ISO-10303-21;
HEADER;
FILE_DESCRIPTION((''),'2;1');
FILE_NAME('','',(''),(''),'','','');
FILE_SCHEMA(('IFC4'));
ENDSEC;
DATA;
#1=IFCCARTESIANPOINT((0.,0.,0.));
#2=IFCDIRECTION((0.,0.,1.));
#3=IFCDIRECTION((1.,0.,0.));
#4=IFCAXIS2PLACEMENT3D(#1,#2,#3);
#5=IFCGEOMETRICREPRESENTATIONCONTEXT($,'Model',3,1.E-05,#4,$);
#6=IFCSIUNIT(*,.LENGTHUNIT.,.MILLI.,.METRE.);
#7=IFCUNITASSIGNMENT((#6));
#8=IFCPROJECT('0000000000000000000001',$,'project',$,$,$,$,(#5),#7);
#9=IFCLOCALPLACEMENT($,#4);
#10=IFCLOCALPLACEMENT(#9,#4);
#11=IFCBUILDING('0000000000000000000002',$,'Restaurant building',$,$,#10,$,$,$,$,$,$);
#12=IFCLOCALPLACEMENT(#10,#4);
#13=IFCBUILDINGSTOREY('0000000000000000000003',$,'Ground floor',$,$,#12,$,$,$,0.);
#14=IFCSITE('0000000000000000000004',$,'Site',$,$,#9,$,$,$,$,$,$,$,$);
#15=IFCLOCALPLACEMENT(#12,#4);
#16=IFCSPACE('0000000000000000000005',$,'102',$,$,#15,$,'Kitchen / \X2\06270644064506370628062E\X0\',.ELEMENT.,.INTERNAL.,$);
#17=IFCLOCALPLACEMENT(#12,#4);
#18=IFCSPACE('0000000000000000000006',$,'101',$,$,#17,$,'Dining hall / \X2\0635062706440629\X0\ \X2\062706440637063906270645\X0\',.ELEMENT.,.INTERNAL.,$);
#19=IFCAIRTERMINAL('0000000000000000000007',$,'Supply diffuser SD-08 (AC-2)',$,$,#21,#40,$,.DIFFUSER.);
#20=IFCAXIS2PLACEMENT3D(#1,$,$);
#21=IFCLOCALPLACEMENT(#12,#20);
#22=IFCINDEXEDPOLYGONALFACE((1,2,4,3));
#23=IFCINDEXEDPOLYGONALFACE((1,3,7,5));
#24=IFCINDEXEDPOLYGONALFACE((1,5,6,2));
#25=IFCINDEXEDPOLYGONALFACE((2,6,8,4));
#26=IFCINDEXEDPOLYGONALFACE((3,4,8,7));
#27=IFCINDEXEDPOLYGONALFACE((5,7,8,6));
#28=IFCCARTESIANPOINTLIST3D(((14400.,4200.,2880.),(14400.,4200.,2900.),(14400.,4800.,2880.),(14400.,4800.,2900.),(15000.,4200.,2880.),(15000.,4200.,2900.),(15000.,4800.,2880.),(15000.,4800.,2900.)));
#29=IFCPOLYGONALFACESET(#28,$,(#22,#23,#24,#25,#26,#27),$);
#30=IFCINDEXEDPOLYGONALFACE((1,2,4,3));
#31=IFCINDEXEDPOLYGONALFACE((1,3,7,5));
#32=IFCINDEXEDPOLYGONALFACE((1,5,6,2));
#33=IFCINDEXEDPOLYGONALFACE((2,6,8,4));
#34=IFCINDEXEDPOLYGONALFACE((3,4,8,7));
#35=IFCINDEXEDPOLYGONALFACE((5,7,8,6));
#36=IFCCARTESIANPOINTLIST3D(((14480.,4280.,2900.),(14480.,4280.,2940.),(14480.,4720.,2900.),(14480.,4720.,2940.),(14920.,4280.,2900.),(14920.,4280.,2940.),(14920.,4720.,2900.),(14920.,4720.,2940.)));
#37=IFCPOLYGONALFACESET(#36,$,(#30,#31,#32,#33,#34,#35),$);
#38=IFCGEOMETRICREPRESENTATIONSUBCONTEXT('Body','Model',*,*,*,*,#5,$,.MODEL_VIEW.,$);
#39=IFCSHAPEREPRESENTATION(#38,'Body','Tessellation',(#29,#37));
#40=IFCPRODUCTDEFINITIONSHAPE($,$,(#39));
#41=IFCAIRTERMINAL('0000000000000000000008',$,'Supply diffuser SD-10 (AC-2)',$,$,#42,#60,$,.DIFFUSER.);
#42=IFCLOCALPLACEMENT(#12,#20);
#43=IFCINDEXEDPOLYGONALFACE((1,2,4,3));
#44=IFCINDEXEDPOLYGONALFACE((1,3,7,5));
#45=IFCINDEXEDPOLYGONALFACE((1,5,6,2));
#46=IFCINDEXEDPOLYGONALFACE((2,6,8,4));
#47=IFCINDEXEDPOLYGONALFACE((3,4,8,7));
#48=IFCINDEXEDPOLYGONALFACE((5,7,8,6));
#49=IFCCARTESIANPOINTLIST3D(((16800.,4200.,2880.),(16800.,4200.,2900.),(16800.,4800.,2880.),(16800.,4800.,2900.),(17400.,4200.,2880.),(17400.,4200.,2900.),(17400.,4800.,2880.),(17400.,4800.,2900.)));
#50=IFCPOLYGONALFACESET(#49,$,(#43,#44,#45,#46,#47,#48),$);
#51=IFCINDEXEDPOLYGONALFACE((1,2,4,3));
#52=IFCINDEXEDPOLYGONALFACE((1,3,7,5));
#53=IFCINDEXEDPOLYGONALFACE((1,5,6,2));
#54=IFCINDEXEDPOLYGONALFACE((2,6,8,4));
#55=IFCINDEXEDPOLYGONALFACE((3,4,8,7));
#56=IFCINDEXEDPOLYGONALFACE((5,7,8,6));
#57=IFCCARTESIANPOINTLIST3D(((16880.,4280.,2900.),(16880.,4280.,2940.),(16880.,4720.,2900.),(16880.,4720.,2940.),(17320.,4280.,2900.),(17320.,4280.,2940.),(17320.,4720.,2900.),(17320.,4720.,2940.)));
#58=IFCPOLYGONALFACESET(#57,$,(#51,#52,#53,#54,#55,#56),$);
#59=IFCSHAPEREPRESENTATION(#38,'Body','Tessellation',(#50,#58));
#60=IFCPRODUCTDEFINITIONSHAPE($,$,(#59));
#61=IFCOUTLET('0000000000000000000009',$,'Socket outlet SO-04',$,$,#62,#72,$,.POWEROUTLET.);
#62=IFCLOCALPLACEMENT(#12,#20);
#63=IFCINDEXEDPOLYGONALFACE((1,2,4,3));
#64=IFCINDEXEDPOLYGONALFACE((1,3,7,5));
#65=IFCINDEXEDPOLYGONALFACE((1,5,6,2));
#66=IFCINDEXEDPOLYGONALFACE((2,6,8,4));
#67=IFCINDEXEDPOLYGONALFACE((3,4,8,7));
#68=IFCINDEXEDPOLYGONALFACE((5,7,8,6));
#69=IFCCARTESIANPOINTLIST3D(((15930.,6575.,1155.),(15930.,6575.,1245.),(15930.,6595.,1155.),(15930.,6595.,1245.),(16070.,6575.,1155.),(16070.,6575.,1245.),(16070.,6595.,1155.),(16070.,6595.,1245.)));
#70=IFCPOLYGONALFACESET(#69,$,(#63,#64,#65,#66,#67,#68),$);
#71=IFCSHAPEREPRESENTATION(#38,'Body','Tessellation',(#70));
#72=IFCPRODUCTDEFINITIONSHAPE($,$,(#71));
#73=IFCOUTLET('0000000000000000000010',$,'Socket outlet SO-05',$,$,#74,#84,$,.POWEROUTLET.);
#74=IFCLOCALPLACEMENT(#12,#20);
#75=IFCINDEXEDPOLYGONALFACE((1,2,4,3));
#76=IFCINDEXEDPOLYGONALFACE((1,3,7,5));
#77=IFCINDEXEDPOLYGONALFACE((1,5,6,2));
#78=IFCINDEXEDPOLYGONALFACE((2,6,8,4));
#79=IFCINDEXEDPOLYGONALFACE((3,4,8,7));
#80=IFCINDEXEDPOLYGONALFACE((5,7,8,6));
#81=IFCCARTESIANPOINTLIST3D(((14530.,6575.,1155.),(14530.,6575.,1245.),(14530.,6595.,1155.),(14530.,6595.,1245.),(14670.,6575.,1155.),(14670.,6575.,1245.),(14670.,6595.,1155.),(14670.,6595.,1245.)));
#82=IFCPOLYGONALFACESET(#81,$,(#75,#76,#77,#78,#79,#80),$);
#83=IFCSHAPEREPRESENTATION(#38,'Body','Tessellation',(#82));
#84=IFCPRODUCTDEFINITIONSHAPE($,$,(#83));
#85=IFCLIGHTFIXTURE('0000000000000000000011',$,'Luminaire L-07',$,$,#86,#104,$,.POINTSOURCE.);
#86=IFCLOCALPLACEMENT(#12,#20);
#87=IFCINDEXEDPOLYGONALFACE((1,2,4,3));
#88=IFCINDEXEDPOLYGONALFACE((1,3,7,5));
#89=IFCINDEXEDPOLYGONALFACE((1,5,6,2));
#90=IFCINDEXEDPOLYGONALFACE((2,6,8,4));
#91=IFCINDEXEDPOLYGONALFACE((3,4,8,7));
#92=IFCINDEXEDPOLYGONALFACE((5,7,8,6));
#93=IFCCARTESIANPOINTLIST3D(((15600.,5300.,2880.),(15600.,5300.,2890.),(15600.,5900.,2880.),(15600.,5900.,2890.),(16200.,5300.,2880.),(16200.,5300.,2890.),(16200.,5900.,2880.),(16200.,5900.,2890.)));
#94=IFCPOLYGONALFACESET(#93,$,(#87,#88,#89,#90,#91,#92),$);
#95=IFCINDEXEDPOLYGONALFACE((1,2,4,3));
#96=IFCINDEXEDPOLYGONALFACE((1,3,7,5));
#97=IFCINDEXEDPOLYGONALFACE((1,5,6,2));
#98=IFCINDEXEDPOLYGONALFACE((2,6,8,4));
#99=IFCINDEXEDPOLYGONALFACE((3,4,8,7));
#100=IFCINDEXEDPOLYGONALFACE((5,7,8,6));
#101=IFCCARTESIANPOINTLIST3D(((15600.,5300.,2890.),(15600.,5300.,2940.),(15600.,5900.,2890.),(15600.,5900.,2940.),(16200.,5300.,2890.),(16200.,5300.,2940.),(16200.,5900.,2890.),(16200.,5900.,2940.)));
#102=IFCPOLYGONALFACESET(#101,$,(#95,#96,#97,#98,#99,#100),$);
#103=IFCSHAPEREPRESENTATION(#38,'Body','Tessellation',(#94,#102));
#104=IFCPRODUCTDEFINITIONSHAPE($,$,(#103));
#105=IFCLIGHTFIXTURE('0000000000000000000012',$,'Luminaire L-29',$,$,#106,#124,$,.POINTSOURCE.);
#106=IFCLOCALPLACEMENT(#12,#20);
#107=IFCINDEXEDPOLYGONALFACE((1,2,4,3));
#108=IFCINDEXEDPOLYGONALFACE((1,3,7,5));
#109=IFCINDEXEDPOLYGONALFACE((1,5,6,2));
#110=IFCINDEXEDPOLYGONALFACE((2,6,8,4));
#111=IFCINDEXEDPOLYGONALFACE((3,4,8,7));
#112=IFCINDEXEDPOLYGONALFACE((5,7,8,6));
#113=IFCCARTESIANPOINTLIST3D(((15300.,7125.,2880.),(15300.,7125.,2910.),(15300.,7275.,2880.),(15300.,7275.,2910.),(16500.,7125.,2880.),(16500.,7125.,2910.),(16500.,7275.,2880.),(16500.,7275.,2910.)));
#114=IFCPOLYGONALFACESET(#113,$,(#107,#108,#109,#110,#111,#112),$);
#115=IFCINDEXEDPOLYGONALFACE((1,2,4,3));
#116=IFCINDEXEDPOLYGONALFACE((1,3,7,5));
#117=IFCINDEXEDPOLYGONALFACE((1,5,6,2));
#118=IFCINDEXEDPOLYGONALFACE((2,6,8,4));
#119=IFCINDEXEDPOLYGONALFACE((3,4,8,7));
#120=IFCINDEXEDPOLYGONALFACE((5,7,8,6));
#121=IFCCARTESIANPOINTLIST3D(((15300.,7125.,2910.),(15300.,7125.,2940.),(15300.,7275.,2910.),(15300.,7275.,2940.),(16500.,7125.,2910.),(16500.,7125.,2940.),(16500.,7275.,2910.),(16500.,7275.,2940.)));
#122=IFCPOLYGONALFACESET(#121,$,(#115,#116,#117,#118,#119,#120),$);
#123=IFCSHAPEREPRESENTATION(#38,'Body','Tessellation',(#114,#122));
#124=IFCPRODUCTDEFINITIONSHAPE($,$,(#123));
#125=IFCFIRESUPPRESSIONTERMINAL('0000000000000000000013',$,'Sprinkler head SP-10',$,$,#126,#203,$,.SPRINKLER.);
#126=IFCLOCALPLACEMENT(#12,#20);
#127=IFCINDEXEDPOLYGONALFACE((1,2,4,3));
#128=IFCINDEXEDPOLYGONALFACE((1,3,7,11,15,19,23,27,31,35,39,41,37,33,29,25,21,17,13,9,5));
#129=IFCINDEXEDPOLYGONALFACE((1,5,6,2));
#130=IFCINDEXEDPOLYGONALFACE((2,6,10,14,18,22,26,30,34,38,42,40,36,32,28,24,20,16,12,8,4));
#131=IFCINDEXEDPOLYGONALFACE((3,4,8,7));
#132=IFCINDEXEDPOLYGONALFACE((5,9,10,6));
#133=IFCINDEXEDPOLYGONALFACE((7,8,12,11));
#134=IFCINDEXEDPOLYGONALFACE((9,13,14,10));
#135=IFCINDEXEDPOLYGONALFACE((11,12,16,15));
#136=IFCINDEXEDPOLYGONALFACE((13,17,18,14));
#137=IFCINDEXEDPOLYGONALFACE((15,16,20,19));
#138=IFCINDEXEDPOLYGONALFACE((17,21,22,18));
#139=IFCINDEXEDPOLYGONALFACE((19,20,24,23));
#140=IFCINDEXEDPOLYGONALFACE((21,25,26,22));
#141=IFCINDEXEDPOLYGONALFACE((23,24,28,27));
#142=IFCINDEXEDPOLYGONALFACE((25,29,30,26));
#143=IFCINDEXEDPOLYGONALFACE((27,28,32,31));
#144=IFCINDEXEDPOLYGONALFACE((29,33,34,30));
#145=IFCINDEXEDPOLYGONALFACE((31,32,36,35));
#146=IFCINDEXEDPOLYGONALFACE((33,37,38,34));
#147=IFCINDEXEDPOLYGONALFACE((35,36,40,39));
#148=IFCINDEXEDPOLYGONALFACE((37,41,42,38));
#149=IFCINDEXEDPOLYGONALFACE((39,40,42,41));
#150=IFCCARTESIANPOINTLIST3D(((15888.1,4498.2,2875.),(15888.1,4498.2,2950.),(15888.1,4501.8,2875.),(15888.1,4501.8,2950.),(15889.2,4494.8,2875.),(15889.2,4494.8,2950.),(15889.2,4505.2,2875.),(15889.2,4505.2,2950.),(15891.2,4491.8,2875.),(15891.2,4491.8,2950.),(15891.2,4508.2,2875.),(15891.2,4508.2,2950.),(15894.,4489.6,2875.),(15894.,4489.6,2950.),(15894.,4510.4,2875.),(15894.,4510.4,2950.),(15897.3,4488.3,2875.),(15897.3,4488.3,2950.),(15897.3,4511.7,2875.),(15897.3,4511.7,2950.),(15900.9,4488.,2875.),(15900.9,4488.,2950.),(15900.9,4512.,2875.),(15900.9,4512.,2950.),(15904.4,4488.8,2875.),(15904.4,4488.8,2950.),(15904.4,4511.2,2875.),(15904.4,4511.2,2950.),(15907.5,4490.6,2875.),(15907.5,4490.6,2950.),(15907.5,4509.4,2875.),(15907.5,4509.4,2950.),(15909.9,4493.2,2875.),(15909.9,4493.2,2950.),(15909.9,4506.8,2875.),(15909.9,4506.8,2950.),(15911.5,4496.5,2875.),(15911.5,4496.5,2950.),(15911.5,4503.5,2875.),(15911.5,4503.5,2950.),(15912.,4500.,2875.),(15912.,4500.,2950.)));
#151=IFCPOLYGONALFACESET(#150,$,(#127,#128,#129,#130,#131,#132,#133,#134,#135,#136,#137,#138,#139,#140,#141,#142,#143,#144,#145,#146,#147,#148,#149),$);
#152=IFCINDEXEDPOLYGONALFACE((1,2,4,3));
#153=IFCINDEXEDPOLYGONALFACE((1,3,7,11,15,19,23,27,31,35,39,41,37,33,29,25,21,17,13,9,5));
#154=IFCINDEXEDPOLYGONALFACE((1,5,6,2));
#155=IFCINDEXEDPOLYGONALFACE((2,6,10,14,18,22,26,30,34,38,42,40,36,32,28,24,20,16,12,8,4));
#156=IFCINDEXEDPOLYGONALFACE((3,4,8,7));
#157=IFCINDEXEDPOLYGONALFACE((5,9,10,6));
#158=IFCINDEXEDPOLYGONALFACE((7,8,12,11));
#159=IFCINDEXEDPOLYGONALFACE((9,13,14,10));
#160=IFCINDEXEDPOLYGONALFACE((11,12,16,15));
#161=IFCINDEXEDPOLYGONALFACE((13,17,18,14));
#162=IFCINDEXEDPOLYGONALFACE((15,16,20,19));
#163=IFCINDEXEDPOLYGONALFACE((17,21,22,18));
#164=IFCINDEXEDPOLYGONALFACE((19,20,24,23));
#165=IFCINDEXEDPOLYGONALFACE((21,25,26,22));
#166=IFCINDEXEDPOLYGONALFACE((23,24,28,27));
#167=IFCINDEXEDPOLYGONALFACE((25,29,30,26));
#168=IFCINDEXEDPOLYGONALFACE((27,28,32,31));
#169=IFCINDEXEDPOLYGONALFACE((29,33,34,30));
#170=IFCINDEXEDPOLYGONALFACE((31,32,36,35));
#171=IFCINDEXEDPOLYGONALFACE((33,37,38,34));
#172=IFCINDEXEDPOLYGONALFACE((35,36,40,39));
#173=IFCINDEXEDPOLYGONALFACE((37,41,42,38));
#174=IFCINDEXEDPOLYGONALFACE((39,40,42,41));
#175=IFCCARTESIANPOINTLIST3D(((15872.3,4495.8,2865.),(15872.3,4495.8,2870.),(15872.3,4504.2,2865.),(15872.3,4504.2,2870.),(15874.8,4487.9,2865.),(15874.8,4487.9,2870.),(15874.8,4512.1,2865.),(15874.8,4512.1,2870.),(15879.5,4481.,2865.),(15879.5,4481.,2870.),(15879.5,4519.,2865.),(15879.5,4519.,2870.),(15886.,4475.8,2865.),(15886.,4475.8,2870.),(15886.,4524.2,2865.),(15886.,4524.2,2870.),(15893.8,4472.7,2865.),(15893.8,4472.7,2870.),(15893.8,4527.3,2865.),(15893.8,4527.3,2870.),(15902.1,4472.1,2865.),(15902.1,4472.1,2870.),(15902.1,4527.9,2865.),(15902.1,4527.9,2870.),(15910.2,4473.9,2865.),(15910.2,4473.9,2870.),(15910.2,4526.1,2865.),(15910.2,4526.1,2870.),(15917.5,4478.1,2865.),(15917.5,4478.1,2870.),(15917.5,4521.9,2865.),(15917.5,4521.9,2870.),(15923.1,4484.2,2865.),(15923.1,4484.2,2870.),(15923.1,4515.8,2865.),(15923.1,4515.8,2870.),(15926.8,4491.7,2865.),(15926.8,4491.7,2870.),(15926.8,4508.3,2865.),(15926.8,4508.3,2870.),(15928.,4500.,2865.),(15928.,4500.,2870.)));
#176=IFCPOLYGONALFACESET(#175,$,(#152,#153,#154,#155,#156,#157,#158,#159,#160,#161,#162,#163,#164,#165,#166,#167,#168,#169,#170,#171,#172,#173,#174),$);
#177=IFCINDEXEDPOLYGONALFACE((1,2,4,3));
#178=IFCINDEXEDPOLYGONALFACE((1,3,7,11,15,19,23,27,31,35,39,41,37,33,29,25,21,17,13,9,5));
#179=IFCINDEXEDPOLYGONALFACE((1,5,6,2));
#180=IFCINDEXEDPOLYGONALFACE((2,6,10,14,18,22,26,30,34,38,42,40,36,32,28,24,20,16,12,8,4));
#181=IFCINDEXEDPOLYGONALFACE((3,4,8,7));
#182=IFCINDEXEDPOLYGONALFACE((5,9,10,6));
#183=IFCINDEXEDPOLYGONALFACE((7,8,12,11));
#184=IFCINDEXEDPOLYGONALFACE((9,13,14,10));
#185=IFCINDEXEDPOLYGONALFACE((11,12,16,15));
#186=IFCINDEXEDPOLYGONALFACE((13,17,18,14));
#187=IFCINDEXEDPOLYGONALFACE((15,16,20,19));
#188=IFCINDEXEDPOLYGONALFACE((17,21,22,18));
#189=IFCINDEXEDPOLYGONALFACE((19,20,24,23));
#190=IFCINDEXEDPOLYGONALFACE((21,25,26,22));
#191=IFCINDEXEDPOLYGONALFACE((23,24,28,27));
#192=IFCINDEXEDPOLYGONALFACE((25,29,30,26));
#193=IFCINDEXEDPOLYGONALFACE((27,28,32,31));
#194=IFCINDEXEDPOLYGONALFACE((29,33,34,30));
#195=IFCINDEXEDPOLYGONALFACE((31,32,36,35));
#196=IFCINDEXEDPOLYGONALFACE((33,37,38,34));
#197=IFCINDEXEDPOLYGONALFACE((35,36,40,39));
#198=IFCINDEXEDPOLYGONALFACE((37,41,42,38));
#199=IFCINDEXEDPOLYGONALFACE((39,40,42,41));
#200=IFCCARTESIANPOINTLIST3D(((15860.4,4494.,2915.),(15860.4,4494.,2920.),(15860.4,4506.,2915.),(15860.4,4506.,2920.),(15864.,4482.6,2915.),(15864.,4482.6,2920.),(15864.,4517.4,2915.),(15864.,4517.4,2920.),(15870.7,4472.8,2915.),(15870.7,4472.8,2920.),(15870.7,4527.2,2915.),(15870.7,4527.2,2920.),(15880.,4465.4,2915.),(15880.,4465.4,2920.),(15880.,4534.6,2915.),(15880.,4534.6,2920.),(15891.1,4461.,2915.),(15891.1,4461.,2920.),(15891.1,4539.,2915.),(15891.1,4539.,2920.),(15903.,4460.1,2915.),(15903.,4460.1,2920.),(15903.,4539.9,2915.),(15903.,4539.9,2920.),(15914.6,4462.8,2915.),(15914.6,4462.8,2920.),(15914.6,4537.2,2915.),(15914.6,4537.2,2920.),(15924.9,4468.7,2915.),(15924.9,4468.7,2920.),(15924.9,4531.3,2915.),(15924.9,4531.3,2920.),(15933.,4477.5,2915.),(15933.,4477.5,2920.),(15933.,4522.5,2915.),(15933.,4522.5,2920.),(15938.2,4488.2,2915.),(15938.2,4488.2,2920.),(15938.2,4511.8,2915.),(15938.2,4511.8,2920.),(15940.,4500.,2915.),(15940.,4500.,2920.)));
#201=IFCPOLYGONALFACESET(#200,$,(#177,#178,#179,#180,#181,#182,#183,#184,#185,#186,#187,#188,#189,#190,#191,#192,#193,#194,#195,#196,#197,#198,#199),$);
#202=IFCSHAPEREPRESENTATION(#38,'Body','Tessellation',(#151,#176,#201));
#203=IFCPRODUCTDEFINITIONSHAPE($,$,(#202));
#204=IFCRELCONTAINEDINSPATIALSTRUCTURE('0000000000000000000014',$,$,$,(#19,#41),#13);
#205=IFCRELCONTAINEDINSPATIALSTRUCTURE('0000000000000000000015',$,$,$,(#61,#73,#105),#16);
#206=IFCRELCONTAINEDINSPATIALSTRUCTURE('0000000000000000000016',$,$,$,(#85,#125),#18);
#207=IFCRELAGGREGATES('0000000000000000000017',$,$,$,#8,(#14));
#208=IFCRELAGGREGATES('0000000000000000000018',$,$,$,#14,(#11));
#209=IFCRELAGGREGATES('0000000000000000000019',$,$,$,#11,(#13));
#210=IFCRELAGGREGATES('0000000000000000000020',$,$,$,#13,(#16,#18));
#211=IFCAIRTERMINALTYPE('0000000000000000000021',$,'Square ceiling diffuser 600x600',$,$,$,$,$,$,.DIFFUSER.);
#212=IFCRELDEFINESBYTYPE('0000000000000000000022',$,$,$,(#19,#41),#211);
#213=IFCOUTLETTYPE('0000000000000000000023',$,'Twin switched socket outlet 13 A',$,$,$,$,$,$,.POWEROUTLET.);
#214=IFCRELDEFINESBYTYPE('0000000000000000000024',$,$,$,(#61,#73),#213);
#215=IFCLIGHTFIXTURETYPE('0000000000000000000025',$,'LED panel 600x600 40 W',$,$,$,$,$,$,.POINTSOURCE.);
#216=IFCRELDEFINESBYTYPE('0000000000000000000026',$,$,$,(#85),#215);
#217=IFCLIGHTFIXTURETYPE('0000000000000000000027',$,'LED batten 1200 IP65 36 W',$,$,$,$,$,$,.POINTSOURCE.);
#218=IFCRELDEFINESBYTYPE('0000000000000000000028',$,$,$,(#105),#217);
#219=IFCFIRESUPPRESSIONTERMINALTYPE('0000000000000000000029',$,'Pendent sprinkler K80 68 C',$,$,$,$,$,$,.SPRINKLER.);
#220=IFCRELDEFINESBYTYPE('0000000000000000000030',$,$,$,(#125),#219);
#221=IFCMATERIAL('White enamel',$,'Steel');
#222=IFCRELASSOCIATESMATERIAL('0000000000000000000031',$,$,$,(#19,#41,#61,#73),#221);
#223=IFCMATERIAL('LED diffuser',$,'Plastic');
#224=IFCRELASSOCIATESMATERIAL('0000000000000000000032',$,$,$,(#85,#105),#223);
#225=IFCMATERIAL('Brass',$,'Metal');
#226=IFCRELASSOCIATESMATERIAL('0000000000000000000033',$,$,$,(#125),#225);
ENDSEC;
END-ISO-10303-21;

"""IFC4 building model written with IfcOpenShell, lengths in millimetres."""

from ifc_helpers import new_model, si_unit, frame, origin, origin_with_axes, origin_2d, place, context, subcontext, project, spatial, rectangle, circle, extrude, source, transform, mapped, material, type_object, type_shapes, element, save


model = new_model("IFC4")

# Units and contexts
model_context = context("Model", 3, precision=1e-05, world=origin_with_axes())
body_context = subcontext(model_context, "Body", "Model", "MODEL_VIEW")
ifc_project = project(units=[si_unit("LENGTHUNIT", "METRE", prefix="MILLI")], contexts=[model_context])

# Site, building, storey
site_placement = place(None, origin_with_axes())
site = spatial("IfcSite", under=ifc_project, at=site_placement, Name="Site")
building_placement = place(site_placement, origin_with_axes())
building = spatial("IfcBuilding", under=site, at=building_placement, Name="Restaurant building")
storey_placement = place(building_placement, origin_with_axes())
storey = spatial("IfcBuildingStorey", under=building, at=storey_placement, Name="Ground floor", Elevation=0.0)

# Air terminals
ifc_material_1 = material(Name="White enamel", Category="Steel")
air_terminal_type = type_object("IfcAirTerminalType", Name="Square ceiling diffuser 600x600", PredefinedType="DIFFUSER")
shared_shape_1 = source(origin(), body_context, "Body", "SweptSolid", [
    extrude(rectangle(XDim=600.0, YDim=600.0, at=origin_2d()), frame((0.0, 0.0, -60.0)), (0.0, 0.0, 1.0), 20.0),
    extrude(rectangle(XDim=440.0, YDim=440.0, at=origin_2d()), frame((0.0, 0.0, -40.0)), (0.0, 0.0, 1.0), 40.0),
])
type_shapes(air_terminal_type, [shared_shape_1])
for number, where, name in (
    (1, (14700.0, 4500.0, 2940.0), "Supply diffuser SD-08 (AC-2)"),
    (2, (17100.0, 4500.0, 2940.0), "Supply diffuser SD-10 (AC-2)"),
):
    element("IfcAirTerminal", number, at=place(storey_placement, frame(where)), inside=storey, type_object=air_terminal_type, material=ifc_material_1, Name=name, PredefinedType="DIFFUSER", context=body_context, shape_type="MappedRepresentation", body=[
        mapped(shared_shape_1, transform((0.0, 0.0, 0.0))),
    ])

# Shared definitions
space_1_placement = place(storey_placement, origin_with_axes())
space_1 = spatial("IfcSpace", under=storey, at=space_1_placement, Name="102", LongName="Kitchen / المطبخ", CompositionType="ELEMENT", PredefinedType="INTERNAL")

# Outlets
outlet_type = type_object("IfcOutletType", Name="Twin switched socket outlet 13 A", PredefinedType="POWEROUTLET")
shared_shape_2 = source(origin(), body_context, "Body", "SweptSolid", [
    extrude(rectangle(XDim=140.0, YDim=20.0, at=origin_2d()), frame((0.0, 10.0, -45.0)), (0.0, 0.0, 1.0), 90.0),
])
type_shapes(outlet_type, [shared_shape_2])
for number, where, name in (
    (3, (16000.0, 6575.0, 1200.0), "Socket outlet SO-04"),
    (4, (14600.0, 6575.0, 1200.0), "Socket outlet SO-05"),
):
    element("IfcOutlet", number, at=place(storey_placement, frame(where)), inside=space_1, type_object=outlet_type, material=ifc_material_1, Name=name, PredefinedType="POWEROUTLET", context=body_context, shape_type="MappedRepresentation", body=[
        mapped(shared_shape_2, transform((0.0, 0.0, 0.0))),
    ])

# Shared definitions
space_2_placement = place(storey_placement, origin_with_axes())
space_2 = spatial("IfcSpace", under=storey, at=space_2_placement, Name="101", LongName="Dining hall / صالة الطعام", CompositionType="ELEMENT", PredefinedType="INTERNAL")

# Light fixtures
ifc_material_2 = material(Name="LED diffuser", Category="Plastic")
light_fixture_type_1 = type_object("IfcLightFixtureType", Name="LED panel 600x600 40 W", PredefinedType="POINTSOURCE")
shared_shape_3 = source(origin(), body_context, "Body", "SweptSolid", [
    extrude(rectangle(XDim=600.0, YDim=600.0, at=origin_2d()), frame((0.0, 0.0, -60.0)), (0.0, 0.0, 1.0), 10.0),
    extrude(rectangle(XDim=600.0, YDim=600.0, at=origin_2d()), frame((0.0, 0.0, -50.0)), (0.0, 0.0, 1.0), 50.0),
])
type_shapes(light_fixture_type_1, [shared_shape_3])
light_fixture_1_placement = place(storey_placement, frame((15900.0, 5600.0, 2940.0)))
element("IfcLightFixture", 5, at=light_fixture_1_placement, inside=space_2, type_object=light_fixture_type_1, material=ifc_material_2, Name="Luminaire L-07", PredefinedType="POINTSOURCE", context=body_context, shape_type="MappedRepresentation", body=[
    mapped(shared_shape_3, transform((0.0, 0.0, 0.0))),
])
light_fixture_type_2 = type_object("IfcLightFixtureType", Name="LED batten 1200 IP65 36 W", PredefinedType="POINTSOURCE")
shared_shape_4 = source(origin(), body_context, "Body", "SweptSolid", [
    extrude(rectangle(XDim=1200.0, YDim=150.0, at=origin_2d()), frame((0.0, 0.0, -60.0)), (0.0, 0.0, 1.0), 30.0),
    extrude(rectangle(XDim=1200.0, YDim=150.0, at=origin_2d()), frame((0.0, 0.0, -30.0)), (0.0, 0.0, 1.0), 30.0),
])
type_shapes(light_fixture_type_2, [shared_shape_4])
light_fixture_2_placement = place(storey_placement, frame((15900.0, 7200.0, 2940.0)))
element("IfcLightFixture", 6, at=light_fixture_2_placement, inside=space_1, type_object=light_fixture_type_2, material=ifc_material_2, Name="Luminaire L-29", PredefinedType="POINTSOURCE", context=body_context, shape_type="MappedRepresentation", body=[
    mapped(shared_shape_4, transform((0.0, 0.0, 0.0))),
])

# Fire suppression terminal
ifc_material_3 = material(Name="Brass", Category="Metal")
fire_suppression_terminal_type = type_object("IfcFireSuppressionTerminalType", Name="Pendent sprinkler K80 68 C", PredefinedType="SPRINKLER")
shared_shape_5 = source(origin(), body_context, "Body", "SweptSolid", [
    extrude(circle(Radius=12.0, at=origin_2d()), frame((0.0, 0.0, -75.0)), (0.0, 0.0, 1.0), 75.0),
    extrude(circle(Radius=28.0, at=origin_2d()), frame((0.0, 0.0, -85.0)), (0.0, 0.0, 1.0), 5.0),
    extrude(circle(Radius=40.0, at=origin_2d()), frame((0.0, 0.0, -35.0)), (0.0, 0.0, 1.0), 5.0),
])
type_shapes(fire_suppression_terminal_type, [shared_shape_5])
fire_suppression_terminal_placement = place(storey_placement, frame((15900.0, 4500.0, 2950.0)))
element("IfcFireSuppressionTerminal", 7, at=fire_suppression_terminal_placement, inside=space_2, type_object=fire_suppression_terminal_type, material=ifc_material_3, Name="Sprinkler head SP-10", PredefinedType="SPRINKLER", context=body_context, shape_type="MappedRepresentation", body=[
    mapped(shared_shape_5, transform((0.0, 0.0, 0.0))),
])

save(model, "model.ifc")
